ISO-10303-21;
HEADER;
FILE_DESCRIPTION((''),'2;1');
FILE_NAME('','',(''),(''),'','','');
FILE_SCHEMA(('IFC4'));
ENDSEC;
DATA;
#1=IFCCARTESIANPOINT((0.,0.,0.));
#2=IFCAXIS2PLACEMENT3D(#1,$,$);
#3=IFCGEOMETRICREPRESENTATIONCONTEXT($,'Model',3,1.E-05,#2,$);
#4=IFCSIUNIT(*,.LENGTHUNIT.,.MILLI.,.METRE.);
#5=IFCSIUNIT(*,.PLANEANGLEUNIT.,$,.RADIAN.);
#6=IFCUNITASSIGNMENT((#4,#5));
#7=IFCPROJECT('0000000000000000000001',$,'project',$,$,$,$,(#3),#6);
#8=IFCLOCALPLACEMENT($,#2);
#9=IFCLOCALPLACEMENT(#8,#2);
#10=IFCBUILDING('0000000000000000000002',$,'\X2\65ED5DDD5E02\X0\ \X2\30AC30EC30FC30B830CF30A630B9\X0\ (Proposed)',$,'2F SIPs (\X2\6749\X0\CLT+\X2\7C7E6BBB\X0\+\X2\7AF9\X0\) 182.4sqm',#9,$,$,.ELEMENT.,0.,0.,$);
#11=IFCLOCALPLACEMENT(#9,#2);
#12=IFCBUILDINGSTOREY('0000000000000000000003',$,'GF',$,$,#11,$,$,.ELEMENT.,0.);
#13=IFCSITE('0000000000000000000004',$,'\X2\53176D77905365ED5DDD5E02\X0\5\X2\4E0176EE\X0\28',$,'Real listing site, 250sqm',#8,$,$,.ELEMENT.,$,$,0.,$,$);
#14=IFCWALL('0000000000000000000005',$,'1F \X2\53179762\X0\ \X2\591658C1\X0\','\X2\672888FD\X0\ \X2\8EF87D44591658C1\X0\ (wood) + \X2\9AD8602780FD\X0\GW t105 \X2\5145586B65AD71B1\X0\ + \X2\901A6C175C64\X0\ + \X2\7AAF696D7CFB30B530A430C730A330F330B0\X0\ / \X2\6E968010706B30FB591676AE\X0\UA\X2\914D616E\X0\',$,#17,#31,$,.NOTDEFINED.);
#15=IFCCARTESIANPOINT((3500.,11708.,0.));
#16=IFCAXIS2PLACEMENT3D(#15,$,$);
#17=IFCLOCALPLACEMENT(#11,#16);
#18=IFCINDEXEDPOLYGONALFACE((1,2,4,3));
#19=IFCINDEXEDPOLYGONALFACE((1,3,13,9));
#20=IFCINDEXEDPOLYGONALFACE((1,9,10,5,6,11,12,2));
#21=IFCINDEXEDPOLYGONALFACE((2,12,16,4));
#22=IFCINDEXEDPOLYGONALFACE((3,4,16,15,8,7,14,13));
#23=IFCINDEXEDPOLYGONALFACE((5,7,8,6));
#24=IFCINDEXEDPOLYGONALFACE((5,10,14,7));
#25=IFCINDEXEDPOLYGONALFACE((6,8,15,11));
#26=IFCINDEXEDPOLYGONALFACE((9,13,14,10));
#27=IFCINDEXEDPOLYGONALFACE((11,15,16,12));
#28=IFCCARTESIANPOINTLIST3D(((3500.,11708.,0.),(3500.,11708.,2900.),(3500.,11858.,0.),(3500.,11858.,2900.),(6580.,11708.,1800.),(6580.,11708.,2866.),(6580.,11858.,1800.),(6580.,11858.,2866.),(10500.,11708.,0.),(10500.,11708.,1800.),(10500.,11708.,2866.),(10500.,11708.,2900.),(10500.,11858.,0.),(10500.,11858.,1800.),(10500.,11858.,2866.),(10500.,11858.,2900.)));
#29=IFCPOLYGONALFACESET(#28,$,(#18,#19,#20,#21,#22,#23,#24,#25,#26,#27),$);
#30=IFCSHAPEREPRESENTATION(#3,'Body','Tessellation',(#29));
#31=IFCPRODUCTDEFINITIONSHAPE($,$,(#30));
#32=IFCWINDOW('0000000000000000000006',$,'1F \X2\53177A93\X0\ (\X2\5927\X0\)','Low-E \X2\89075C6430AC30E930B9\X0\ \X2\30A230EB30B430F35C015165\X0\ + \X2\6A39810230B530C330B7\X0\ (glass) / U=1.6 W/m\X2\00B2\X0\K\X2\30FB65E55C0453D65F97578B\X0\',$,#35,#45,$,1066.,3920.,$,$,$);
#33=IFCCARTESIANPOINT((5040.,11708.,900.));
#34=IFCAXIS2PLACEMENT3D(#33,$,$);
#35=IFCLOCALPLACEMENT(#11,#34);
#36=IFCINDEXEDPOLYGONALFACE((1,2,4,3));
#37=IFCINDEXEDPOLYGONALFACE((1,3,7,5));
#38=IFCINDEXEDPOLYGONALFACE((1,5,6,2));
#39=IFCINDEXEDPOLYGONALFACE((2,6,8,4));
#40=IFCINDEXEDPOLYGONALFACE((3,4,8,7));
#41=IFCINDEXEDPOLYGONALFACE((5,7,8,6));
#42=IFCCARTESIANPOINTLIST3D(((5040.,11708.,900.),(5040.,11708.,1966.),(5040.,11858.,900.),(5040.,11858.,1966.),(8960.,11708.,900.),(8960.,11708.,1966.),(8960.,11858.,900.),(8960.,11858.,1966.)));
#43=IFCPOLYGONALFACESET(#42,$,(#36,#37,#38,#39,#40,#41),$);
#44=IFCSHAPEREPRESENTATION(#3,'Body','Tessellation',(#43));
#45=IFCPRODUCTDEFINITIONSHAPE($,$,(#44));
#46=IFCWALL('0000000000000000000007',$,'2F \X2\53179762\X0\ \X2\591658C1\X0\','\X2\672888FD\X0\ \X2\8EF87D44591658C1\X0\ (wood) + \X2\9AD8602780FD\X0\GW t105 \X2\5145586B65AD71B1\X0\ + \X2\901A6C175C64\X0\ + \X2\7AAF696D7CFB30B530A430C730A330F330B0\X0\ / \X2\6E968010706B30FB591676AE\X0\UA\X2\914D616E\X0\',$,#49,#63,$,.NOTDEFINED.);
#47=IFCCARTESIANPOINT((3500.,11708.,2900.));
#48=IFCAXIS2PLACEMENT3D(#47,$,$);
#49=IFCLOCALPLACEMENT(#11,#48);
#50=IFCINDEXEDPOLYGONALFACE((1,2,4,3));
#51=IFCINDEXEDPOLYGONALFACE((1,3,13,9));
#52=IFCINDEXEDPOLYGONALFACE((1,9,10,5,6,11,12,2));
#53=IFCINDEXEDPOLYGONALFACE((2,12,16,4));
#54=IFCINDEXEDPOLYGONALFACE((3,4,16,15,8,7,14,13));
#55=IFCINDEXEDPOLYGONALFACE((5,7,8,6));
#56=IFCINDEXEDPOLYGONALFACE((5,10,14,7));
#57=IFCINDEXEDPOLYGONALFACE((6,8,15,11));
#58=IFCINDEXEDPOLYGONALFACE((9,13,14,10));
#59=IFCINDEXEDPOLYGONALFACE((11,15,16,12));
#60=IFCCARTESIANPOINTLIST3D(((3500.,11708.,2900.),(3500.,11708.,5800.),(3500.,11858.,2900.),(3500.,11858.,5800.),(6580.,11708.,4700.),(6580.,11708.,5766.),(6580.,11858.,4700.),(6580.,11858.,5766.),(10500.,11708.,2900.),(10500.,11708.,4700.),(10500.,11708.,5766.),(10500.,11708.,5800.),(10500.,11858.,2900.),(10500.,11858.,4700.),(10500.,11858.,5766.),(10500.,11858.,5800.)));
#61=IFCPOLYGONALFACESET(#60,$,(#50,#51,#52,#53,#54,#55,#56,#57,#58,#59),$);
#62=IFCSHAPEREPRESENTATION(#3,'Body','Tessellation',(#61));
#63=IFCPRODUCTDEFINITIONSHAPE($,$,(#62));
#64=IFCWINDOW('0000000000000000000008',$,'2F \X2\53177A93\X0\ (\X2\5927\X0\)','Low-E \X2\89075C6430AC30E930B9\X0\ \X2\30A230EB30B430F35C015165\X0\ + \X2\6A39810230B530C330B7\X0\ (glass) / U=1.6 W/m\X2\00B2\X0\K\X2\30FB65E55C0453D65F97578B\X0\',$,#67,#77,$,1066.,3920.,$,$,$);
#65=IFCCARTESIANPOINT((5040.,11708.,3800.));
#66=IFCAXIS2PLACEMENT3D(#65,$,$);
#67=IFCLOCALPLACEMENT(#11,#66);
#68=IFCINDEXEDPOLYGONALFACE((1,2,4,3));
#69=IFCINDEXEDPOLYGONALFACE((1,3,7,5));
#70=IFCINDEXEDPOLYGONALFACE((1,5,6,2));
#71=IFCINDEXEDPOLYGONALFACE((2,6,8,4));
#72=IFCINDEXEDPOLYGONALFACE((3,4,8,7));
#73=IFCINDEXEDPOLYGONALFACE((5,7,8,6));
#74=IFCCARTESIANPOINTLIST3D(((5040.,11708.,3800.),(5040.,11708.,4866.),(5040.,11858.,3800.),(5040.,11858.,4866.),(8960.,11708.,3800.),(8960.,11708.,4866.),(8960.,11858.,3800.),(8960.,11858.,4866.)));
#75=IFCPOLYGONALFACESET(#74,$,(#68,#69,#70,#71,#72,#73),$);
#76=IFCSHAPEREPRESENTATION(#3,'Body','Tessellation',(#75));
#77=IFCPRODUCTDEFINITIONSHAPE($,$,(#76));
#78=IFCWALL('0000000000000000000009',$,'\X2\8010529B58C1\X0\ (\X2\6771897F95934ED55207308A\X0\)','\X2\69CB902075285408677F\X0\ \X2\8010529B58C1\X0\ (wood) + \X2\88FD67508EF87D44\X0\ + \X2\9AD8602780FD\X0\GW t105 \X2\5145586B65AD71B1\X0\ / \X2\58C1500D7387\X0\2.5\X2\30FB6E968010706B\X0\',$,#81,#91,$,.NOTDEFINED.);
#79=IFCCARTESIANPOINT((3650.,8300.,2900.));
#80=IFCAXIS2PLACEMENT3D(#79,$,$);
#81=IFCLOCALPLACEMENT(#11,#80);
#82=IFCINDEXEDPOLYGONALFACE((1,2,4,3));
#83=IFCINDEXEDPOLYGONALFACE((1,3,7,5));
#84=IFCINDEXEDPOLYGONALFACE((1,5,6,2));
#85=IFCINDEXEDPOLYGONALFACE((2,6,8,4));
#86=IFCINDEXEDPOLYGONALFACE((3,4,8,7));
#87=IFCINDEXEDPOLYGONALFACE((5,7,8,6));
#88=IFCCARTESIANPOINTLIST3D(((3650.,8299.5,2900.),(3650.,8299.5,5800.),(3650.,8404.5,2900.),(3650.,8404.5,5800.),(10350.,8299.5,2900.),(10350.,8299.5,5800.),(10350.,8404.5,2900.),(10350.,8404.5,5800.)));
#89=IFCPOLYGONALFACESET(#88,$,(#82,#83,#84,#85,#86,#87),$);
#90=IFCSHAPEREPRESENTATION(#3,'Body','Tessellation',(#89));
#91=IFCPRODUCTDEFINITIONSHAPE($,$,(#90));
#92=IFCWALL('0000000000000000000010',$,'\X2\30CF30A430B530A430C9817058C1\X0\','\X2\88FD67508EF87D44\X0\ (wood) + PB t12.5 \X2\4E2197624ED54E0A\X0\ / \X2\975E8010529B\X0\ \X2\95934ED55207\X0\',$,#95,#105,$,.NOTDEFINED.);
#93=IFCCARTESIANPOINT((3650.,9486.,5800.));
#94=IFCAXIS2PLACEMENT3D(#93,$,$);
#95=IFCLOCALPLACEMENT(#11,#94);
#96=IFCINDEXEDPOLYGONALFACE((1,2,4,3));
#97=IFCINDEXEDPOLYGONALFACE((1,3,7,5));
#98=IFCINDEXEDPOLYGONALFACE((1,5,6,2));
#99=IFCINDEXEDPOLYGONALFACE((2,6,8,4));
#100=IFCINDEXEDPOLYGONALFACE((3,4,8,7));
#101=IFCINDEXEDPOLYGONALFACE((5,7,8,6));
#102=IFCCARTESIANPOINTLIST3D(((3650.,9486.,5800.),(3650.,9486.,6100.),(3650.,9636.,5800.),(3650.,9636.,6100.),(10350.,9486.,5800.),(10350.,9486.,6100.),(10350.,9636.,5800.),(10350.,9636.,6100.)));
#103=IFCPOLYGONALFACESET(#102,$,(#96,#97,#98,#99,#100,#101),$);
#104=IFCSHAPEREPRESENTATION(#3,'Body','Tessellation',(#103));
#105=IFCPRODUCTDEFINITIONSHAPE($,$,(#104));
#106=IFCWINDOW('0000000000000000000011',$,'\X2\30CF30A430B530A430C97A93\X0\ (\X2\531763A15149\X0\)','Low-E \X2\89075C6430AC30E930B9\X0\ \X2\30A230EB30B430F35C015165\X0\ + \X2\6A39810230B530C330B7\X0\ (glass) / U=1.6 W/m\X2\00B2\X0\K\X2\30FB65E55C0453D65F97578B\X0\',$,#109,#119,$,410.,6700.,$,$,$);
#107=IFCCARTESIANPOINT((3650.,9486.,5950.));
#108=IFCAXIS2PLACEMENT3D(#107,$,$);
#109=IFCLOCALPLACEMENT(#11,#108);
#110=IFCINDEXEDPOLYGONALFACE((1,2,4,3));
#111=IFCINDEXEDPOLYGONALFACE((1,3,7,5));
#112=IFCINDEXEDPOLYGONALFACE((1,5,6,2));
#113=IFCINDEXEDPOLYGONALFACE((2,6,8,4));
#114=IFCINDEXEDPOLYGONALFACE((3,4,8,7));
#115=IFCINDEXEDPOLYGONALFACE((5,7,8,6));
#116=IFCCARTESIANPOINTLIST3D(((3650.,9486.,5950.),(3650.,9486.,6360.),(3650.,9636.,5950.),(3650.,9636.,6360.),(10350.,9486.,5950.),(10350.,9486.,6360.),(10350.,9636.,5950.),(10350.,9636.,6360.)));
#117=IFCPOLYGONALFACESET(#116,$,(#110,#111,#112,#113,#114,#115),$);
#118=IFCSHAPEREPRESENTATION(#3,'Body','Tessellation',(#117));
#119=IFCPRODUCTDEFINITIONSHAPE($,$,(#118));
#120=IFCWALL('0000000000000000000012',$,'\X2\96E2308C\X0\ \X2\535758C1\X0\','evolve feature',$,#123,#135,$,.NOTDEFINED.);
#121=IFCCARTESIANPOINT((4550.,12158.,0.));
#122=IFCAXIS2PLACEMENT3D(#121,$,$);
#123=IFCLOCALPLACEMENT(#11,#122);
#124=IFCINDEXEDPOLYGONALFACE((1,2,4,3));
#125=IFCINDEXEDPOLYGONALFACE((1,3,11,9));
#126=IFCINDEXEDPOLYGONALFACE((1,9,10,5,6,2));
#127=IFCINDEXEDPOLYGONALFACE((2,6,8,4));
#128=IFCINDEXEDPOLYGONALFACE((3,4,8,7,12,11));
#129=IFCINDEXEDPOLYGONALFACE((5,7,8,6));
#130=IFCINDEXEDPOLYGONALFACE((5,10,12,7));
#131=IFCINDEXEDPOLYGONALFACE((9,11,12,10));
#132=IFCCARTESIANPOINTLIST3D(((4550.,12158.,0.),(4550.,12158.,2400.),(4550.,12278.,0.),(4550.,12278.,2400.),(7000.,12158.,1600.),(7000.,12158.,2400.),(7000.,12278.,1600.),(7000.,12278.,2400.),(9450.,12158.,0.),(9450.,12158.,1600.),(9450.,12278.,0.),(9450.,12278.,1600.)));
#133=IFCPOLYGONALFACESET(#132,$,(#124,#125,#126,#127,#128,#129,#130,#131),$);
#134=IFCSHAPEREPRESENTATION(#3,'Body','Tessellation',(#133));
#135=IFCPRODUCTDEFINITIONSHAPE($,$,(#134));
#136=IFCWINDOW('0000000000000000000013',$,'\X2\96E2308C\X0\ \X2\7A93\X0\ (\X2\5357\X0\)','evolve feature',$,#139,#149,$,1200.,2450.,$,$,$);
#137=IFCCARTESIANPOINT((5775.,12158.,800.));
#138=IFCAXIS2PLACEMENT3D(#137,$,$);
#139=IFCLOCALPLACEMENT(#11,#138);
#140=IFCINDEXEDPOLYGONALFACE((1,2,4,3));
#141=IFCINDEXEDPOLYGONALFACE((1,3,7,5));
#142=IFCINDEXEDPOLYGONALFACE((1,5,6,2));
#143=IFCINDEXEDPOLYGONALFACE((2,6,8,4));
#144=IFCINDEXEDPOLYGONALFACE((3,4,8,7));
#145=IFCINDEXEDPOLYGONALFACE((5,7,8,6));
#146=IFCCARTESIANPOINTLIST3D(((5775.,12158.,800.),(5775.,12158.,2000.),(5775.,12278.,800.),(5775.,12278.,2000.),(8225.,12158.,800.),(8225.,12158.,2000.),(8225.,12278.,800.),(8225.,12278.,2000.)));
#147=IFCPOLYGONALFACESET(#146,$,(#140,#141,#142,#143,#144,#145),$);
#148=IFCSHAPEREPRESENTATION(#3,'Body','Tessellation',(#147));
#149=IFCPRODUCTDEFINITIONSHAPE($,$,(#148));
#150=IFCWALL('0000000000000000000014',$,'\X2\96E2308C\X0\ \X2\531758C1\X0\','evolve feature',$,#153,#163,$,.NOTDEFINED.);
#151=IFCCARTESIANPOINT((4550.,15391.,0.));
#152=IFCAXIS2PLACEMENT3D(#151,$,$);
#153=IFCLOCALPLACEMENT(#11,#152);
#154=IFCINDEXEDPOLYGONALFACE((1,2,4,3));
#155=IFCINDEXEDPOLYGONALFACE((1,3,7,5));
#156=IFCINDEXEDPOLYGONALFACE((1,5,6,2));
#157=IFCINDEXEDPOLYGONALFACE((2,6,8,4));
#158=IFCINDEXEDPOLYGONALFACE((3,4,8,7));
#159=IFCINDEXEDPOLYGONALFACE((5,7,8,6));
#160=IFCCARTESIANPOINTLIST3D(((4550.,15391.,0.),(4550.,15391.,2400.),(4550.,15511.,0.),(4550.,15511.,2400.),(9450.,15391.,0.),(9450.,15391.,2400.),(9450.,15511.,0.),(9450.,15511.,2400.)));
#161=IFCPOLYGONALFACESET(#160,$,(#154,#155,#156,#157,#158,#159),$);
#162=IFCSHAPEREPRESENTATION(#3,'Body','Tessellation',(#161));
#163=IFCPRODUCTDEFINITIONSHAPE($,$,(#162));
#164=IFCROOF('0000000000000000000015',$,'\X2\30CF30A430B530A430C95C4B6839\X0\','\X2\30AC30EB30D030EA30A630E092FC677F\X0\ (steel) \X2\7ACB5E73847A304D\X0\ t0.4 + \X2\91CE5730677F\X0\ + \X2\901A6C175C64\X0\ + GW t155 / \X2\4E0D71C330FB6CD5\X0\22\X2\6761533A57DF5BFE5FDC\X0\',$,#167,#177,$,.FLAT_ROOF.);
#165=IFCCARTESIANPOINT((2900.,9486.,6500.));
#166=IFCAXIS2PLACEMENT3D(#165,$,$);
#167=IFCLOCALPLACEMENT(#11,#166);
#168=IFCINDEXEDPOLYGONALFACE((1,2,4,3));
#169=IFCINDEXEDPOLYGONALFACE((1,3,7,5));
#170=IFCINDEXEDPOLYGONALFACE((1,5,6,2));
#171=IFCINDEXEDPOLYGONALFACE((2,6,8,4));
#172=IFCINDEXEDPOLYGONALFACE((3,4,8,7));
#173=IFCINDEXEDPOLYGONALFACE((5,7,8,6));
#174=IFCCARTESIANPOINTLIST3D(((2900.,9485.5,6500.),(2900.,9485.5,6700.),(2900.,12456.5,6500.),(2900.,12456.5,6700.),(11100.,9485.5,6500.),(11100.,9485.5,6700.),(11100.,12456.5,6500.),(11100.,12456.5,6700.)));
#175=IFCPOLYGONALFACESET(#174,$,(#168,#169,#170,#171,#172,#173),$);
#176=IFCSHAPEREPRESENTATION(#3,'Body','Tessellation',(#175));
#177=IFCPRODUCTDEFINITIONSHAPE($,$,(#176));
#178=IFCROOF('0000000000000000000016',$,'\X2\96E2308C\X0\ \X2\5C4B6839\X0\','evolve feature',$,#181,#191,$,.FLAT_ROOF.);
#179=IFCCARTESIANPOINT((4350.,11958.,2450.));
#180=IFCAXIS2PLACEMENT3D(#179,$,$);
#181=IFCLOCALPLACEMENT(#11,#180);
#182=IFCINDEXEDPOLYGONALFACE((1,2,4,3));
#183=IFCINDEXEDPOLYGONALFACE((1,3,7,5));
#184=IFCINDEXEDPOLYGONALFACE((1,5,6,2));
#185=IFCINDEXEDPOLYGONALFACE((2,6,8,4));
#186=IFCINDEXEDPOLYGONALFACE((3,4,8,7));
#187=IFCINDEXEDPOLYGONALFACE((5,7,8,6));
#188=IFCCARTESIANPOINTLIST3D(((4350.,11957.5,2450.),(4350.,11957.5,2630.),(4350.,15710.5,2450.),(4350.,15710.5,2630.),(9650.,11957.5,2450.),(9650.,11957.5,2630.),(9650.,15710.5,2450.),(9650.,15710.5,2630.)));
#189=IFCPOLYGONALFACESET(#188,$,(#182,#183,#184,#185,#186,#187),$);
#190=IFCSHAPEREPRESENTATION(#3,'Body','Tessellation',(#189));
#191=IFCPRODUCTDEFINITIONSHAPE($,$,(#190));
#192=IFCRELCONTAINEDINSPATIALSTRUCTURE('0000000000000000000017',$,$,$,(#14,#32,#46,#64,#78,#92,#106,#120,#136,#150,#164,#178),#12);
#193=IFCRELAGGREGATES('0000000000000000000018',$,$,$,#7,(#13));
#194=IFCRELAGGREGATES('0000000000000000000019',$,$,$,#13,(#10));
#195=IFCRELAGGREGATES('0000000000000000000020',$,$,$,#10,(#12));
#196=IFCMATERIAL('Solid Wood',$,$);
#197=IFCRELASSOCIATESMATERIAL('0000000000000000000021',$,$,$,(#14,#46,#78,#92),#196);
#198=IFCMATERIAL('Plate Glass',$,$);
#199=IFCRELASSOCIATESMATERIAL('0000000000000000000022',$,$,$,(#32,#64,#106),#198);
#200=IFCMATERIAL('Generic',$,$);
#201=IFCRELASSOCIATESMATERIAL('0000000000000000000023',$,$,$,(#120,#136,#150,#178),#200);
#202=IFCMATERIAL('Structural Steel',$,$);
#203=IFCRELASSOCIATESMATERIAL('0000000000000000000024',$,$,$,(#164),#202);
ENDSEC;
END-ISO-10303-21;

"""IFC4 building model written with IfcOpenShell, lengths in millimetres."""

from ifc_helpers import new_model, si_unit, frame, frame_2d, origin, place, context, project, spatial, rectangle, extrude, material, element, fill, save


model = new_model("IFC4")

# Units and contexts
model_context = context("Model", 3, precision=1e-05, world=origin())
ifc_project = project(units=[si_unit("LENGTHUNIT", "METRE", prefix="MILLI"), si_unit("PLANEANGLEUNIT", "RADIAN")], contexts=[model_context])

# Site, building, storey
site_placement = place(None, origin())
site = spatial("IfcSite", under=ifc_project, at=site_placement, Name="北海道旭川市5丁目28", ObjectType="Real listing site, 250sqm", CompositionType="ELEMENT", RefElevation=0.0)
building_placement = place(site_placement, origin())
building = spatial("IfcBuilding", under=site, at=building_placement, Name="旭川市 ガレージハウス (Proposed)", ObjectType="2F SIPs (杉CLT+籾殻+竹) 182.4sqm", CompositionType="ELEMENT", ElevationOfRefHeight=0.0, ElevationOfTerrain=0.0)
storey_placement = place(building_placement, origin())
storey = spatial("IfcBuildingStorey", under=building, at=storey_placement, Name="GF", CompositionType="ELEMENT", Elevation=0.0)

# Shared definitions
ifc_material_1 = material(Name="Generic")

# Wall, opening, window
ifc_material_2 = material(Name="Solid Wood")
wall_1_placement = place(storey_placement, frame((3500.0, 11708.0, 0.0)))
wall_1 = element("IfcWall", 1, at=wall_1_placement, inside=storey, material=ifc_material_2, Name="1F 北面 外壁", Description="木製 軸組外壁 (wood) + 高性能GW t105 充填断熱 + 通気層 + 窯業系サイディング / 準耐火・外皮UA配慮", PredefinedType="NOTDEFINED", context=model_context, shape_type="SweptSolid", body=[
    extrude(rectangle(XDim=7000.0, YDim=150.0, at=frame_2d((3500.0, 75.0))), frame((3500.0, 11708.0, 0.0)), (0.0, 0.0, 1.0), 2900.0),
])
opening_1_placement = place(storey_placement, frame((5040.0, 11708.0, 900.0)))
opening_1 = element("IfcOpeningElement", 2, at=opening_1_placement, cuts=wall_1, PredefinedType="NOTDEFINED", context=model_context, shape_type="SweptSolid", body=[
    extrude(rectangle(XDim=3920.0, YDim=150.0, at=frame_2d((1960.0, 75.0))), frame((5040.0, 11708.0, 900.0)), (0.0, 0.0, 1.0), 1066.0),
])
ifc_material_3 = material(Name="Plate Glass")
window_1_placement = place(storey_placement, frame((5040.0, 11708.0, 900.0)))
window_1 = element("IfcWindow", 3, at=window_1_placement, inside=storey, material=ifc_material_3, Name="1F 北窓 (大)", Description="Low-E 複層ガラス アルゴン封入 + 樹脂サッシ (glass) / U=1.6 W/m²K・日射取得型", OverallHeight=1066.0, OverallWidth=3920.0, context=model_context, shape_type="SweptSolid", body=[
    extrude(rectangle(XDim=3920.0, YDim=150.0, at=frame_2d((1960.0, 75.0))), frame((5040.0, 11708.0, 900.0)), (0.0, 0.0, 1.0), 1066.0),
])
fill(opening_1, window_1)

# Wall, opening, window
wall_2_placement = place(storey_placement, frame((3500.0, 11708.0, 2900.0)))
wall_2 = element("IfcWall", 4, at=wall_2_placement, inside=storey, material=ifc_material_2, Name="2F 北面 外壁", Description="木製 軸組外壁 (wood) + 高性能GW t105 充填断熱 + 通気層 + 窯業系サイディング / 準耐火・外皮UA配慮", PredefinedType="NOTDEFINED", context=model_context, shape_type="SweptSolid", body=[
    extrude(rectangle(XDim=7000.0, YDim=150.0, at=frame_2d((3500.0, 75.0))), frame((3500.0, 11708.0, 2900.0)), (0.0, 0.0, 1.0), 2900.0),
])
opening_2_placement = place(storey_placement, frame((5040.0, 11708.0, 3800.0)))
opening_2 = element("IfcOpeningElement", 5, at=opening_2_placement, cuts=wall_2, PredefinedType="NOTDEFINED", context=model_context, shape_type="SweptSolid", body=[
    extrude(rectangle(XDim=3920.0, YDim=150.0, at=frame_2d((1960.0, 75.0))), frame((5040.0, 11708.0, 3800.0)), (0.0, 0.0, 1.0), 1066.0),
])
window_2_placement = place(storey_placement, frame((5040.0, 11708.0, 3800.0)))
window_2 = element("IfcWindow", 6, at=window_2_placement, inside=storey, material=ifc_material_3, Name="2F 北窓 (大)", Description="Low-E 複層ガラス アルゴン封入 + 樹脂サッシ (glass) / U=1.6 W/m²K・日射取得型", OverallHeight=1066.0, OverallWidth=3920.0, context=model_context, shape_type="SweptSolid", body=[
    extrude(rectangle(XDim=3920.0, YDim=150.0, at=frame_2d((1960.0, 75.0))), frame((5040.0, 11708.0, 3800.0)), (0.0, 0.0, 1.0), 1066.0),
])
fill(opening_2, window_2)

# Wall
wall_3_placement = place(storey_placement, frame((3650.0, 8300.0, 2900.0)))
element("IfcWall", 7, at=wall_3_placement, inside=storey, material=ifc_material_2, Name="耐力壁 (東西間仕切り)", Description="構造用合板 耐力壁 (wood) + 製材軸組 + 高性能GW t105 充填断熱 / 壁倍率2.5・準耐火", PredefinedType="NOTDEFINED", context=model_context, shape_type="SweptSolid", body=[
    extrude(rectangle(XDim=6700.0, YDim=105.0, at=frame_2d((3350.0, 52.0))), frame((3650.0, 8300.0, 2900.0)), (0.0, 0.0, 1.0), 2900.0),
])

# Walls, openings, windows
wall_4_placement = place(storey_placement, frame((3650.0, 9486.0, 5800.0)))
wall_4 = element("IfcWall", 8, at=wall_4_placement, inside=storey, material=ifc_material_2, Name="ハイサイド腰壁", Description="製材軸組 (wood) + PB t12.5 両面仕上 / 非耐力 間仕切", PredefinedType="NOTDEFINED", context=model_context, shape_type="SweptSolid", body=[
    extrude(rectangle(XDim=6700.0, YDim=150.0, at=frame_2d((3350.0, 75.0))), frame((3650.0, 9486.0, 5800.0)), (0.0, 0.0, 1.0), 700.0),
])
opening_3_placement = place(storey_placement, frame((3650.0, 9486.0, 5950.0)))
opening_3 = element("IfcOpeningElement", 9, at=opening_3_placement, cuts=wall_4, PredefinedType="NOTDEFINED", context=model_context, shape_type="SweptSolid", body=[
    extrude(rectangle(XDim=6700.0, YDim=150.0, at=frame_2d((3350.0, 75.0))), frame((3650.0, 9486.0, 5950.0)), (0.0, 0.0, 1.0), 410.0),
])
window_3_placement = place(storey_placement, frame((3650.0, 9486.0, 5950.0)))
window_3 = element("IfcWindow", 10, at=window_3_placement, inside=storey, material=ifc_material_3, Name="ハイサイド窓 (北採光)", Description="Low-E 複層ガラス アルゴン封入 + 樹脂サッシ (glass) / U=1.6 W/m²K・日射取得型", OverallHeight=410.0, OverallWidth=6700.0, context=model_context, shape_type="SweptSolid", body=[
    extrude(rectangle(XDim=6700.0, YDim=150.0, at=frame_2d((3350.0, 75.0))), frame((3650.0, 9486.0, 5950.0)), (0.0, 0.0, 1.0), 410.0),
])
fill(opening_3, window_3)
wall_5_placement = place(storey_placement, frame((4550.0, 12158.0, 0.0)))
wall_5 = element("IfcWall", 11, at=wall_5_placement, inside=storey, material=ifc_material_1, Name="離れ 南壁", Description="evolve feature", PredefinedType="NOTDEFINED", context=model_context, shape_type="SweptSolid", body=[
    extrude(rectangle(XDim=4900.0, YDim=120.0, at=frame_2d((2450.0, 60.0))), frame((4550.0, 12158.0, 0.0)), (0.0, 0.0, 1.0), 2400.0),
])
opening_4_placement = place(storey_placement, frame((5775.0, 12158.0, 800.0)))
opening_4 = element("IfcOpeningElement", 12, at=opening_4_placement, cuts=wall_5, PredefinedType="NOTDEFINED", context=model_context, shape_type="SweptSolid", body=[
    extrude(rectangle(XDim=2450.0, YDim=120.0, at=frame_2d((1225.0, 60.0))), frame((5775.0, 12158.0, 800.0)), (0.0, 0.0, 1.0), 1200.0),
])
window_4_placement = place(storey_placement, frame((5775.0, 12158.0, 800.0)))
window_4 = element("IfcWindow", 13, at=window_4_placement, inside=storey, material=ifc_material_1, Name="離れ 窓 (南)", Description="evolve feature", OverallHeight=1200.0, OverallWidth=2450.0, context=model_context, shape_type="SweptSolid", body=[
    extrude(rectangle(XDim=2450.0, YDim=120.0, at=frame_2d((1225.0, 60.0))), frame((5775.0, 12158.0, 800.0)), (0.0, 0.0, 1.0), 1200.0),
])
fill(opening_4, window_4)

# Wall
wall_6_placement = place(storey_placement, frame((4550.0, 15391.0, 0.0)))
element("IfcWall", 14, at=wall_6_placement, inside=storey, material=ifc_material_1, Name="離れ 北壁", Description="evolve feature", PredefinedType="NOTDEFINED", context=model_context, shape_type="SweptSolid", body=[
    extrude(rectangle(XDim=4900.0, YDim=120.0, at=frame_2d((2450.0, 60.0))), frame((4550.0, 15391.0, 0.0)), (0.0, 0.0, 1.0), 2400.0),
])

# Roofs
ifc_material_4 = material(Name="Structural Steel")
roof_1_placement = place(storey_placement, frame((2900.0, 9486.0, 6500.0)))
element("IfcRoof", 15, at=roof_1_placement, inside=storey, material=ifc_material_4, Name="ハイサイド屋根", Description="ガルバリウム鋼板 (steel) 立平葺き t0.4 + 野地板 + 通気層 + GW t155 / 不燃・法22条区域対応", PredefinedType="FLAT_ROOF", context=model_context, shape_type="SweptSolid", body=[
    extrude(rectangle(XDim=8200.0, YDim=2971.0, at=frame_2d((4100.0, 1485.0))), frame((2900.0, 9486.0, 6500.0)), (0.0, 0.0, 1.0), 200.0),
])
roof_2_placement = place(storey_placement, frame((4350.0, 11958.0, 2450.0)))
element("IfcRoof", 16, at=roof_2_placement, inside=storey, material=ifc_material_1, Name="離れ 屋根", Description="evolve feature", PredefinedType="FLAT_ROOF", context=model_context, shape_type="SweptSolid", body=[
    extrude(rectangle(XDim=5300.0, YDim=3753.0, at=frame_2d((2650.0, 1876.0))), frame((4350.0, 11958.0, 2450.0)), (0.0, 0.0, 1.0), 180.0),
])

save(model, "model.ifc")
